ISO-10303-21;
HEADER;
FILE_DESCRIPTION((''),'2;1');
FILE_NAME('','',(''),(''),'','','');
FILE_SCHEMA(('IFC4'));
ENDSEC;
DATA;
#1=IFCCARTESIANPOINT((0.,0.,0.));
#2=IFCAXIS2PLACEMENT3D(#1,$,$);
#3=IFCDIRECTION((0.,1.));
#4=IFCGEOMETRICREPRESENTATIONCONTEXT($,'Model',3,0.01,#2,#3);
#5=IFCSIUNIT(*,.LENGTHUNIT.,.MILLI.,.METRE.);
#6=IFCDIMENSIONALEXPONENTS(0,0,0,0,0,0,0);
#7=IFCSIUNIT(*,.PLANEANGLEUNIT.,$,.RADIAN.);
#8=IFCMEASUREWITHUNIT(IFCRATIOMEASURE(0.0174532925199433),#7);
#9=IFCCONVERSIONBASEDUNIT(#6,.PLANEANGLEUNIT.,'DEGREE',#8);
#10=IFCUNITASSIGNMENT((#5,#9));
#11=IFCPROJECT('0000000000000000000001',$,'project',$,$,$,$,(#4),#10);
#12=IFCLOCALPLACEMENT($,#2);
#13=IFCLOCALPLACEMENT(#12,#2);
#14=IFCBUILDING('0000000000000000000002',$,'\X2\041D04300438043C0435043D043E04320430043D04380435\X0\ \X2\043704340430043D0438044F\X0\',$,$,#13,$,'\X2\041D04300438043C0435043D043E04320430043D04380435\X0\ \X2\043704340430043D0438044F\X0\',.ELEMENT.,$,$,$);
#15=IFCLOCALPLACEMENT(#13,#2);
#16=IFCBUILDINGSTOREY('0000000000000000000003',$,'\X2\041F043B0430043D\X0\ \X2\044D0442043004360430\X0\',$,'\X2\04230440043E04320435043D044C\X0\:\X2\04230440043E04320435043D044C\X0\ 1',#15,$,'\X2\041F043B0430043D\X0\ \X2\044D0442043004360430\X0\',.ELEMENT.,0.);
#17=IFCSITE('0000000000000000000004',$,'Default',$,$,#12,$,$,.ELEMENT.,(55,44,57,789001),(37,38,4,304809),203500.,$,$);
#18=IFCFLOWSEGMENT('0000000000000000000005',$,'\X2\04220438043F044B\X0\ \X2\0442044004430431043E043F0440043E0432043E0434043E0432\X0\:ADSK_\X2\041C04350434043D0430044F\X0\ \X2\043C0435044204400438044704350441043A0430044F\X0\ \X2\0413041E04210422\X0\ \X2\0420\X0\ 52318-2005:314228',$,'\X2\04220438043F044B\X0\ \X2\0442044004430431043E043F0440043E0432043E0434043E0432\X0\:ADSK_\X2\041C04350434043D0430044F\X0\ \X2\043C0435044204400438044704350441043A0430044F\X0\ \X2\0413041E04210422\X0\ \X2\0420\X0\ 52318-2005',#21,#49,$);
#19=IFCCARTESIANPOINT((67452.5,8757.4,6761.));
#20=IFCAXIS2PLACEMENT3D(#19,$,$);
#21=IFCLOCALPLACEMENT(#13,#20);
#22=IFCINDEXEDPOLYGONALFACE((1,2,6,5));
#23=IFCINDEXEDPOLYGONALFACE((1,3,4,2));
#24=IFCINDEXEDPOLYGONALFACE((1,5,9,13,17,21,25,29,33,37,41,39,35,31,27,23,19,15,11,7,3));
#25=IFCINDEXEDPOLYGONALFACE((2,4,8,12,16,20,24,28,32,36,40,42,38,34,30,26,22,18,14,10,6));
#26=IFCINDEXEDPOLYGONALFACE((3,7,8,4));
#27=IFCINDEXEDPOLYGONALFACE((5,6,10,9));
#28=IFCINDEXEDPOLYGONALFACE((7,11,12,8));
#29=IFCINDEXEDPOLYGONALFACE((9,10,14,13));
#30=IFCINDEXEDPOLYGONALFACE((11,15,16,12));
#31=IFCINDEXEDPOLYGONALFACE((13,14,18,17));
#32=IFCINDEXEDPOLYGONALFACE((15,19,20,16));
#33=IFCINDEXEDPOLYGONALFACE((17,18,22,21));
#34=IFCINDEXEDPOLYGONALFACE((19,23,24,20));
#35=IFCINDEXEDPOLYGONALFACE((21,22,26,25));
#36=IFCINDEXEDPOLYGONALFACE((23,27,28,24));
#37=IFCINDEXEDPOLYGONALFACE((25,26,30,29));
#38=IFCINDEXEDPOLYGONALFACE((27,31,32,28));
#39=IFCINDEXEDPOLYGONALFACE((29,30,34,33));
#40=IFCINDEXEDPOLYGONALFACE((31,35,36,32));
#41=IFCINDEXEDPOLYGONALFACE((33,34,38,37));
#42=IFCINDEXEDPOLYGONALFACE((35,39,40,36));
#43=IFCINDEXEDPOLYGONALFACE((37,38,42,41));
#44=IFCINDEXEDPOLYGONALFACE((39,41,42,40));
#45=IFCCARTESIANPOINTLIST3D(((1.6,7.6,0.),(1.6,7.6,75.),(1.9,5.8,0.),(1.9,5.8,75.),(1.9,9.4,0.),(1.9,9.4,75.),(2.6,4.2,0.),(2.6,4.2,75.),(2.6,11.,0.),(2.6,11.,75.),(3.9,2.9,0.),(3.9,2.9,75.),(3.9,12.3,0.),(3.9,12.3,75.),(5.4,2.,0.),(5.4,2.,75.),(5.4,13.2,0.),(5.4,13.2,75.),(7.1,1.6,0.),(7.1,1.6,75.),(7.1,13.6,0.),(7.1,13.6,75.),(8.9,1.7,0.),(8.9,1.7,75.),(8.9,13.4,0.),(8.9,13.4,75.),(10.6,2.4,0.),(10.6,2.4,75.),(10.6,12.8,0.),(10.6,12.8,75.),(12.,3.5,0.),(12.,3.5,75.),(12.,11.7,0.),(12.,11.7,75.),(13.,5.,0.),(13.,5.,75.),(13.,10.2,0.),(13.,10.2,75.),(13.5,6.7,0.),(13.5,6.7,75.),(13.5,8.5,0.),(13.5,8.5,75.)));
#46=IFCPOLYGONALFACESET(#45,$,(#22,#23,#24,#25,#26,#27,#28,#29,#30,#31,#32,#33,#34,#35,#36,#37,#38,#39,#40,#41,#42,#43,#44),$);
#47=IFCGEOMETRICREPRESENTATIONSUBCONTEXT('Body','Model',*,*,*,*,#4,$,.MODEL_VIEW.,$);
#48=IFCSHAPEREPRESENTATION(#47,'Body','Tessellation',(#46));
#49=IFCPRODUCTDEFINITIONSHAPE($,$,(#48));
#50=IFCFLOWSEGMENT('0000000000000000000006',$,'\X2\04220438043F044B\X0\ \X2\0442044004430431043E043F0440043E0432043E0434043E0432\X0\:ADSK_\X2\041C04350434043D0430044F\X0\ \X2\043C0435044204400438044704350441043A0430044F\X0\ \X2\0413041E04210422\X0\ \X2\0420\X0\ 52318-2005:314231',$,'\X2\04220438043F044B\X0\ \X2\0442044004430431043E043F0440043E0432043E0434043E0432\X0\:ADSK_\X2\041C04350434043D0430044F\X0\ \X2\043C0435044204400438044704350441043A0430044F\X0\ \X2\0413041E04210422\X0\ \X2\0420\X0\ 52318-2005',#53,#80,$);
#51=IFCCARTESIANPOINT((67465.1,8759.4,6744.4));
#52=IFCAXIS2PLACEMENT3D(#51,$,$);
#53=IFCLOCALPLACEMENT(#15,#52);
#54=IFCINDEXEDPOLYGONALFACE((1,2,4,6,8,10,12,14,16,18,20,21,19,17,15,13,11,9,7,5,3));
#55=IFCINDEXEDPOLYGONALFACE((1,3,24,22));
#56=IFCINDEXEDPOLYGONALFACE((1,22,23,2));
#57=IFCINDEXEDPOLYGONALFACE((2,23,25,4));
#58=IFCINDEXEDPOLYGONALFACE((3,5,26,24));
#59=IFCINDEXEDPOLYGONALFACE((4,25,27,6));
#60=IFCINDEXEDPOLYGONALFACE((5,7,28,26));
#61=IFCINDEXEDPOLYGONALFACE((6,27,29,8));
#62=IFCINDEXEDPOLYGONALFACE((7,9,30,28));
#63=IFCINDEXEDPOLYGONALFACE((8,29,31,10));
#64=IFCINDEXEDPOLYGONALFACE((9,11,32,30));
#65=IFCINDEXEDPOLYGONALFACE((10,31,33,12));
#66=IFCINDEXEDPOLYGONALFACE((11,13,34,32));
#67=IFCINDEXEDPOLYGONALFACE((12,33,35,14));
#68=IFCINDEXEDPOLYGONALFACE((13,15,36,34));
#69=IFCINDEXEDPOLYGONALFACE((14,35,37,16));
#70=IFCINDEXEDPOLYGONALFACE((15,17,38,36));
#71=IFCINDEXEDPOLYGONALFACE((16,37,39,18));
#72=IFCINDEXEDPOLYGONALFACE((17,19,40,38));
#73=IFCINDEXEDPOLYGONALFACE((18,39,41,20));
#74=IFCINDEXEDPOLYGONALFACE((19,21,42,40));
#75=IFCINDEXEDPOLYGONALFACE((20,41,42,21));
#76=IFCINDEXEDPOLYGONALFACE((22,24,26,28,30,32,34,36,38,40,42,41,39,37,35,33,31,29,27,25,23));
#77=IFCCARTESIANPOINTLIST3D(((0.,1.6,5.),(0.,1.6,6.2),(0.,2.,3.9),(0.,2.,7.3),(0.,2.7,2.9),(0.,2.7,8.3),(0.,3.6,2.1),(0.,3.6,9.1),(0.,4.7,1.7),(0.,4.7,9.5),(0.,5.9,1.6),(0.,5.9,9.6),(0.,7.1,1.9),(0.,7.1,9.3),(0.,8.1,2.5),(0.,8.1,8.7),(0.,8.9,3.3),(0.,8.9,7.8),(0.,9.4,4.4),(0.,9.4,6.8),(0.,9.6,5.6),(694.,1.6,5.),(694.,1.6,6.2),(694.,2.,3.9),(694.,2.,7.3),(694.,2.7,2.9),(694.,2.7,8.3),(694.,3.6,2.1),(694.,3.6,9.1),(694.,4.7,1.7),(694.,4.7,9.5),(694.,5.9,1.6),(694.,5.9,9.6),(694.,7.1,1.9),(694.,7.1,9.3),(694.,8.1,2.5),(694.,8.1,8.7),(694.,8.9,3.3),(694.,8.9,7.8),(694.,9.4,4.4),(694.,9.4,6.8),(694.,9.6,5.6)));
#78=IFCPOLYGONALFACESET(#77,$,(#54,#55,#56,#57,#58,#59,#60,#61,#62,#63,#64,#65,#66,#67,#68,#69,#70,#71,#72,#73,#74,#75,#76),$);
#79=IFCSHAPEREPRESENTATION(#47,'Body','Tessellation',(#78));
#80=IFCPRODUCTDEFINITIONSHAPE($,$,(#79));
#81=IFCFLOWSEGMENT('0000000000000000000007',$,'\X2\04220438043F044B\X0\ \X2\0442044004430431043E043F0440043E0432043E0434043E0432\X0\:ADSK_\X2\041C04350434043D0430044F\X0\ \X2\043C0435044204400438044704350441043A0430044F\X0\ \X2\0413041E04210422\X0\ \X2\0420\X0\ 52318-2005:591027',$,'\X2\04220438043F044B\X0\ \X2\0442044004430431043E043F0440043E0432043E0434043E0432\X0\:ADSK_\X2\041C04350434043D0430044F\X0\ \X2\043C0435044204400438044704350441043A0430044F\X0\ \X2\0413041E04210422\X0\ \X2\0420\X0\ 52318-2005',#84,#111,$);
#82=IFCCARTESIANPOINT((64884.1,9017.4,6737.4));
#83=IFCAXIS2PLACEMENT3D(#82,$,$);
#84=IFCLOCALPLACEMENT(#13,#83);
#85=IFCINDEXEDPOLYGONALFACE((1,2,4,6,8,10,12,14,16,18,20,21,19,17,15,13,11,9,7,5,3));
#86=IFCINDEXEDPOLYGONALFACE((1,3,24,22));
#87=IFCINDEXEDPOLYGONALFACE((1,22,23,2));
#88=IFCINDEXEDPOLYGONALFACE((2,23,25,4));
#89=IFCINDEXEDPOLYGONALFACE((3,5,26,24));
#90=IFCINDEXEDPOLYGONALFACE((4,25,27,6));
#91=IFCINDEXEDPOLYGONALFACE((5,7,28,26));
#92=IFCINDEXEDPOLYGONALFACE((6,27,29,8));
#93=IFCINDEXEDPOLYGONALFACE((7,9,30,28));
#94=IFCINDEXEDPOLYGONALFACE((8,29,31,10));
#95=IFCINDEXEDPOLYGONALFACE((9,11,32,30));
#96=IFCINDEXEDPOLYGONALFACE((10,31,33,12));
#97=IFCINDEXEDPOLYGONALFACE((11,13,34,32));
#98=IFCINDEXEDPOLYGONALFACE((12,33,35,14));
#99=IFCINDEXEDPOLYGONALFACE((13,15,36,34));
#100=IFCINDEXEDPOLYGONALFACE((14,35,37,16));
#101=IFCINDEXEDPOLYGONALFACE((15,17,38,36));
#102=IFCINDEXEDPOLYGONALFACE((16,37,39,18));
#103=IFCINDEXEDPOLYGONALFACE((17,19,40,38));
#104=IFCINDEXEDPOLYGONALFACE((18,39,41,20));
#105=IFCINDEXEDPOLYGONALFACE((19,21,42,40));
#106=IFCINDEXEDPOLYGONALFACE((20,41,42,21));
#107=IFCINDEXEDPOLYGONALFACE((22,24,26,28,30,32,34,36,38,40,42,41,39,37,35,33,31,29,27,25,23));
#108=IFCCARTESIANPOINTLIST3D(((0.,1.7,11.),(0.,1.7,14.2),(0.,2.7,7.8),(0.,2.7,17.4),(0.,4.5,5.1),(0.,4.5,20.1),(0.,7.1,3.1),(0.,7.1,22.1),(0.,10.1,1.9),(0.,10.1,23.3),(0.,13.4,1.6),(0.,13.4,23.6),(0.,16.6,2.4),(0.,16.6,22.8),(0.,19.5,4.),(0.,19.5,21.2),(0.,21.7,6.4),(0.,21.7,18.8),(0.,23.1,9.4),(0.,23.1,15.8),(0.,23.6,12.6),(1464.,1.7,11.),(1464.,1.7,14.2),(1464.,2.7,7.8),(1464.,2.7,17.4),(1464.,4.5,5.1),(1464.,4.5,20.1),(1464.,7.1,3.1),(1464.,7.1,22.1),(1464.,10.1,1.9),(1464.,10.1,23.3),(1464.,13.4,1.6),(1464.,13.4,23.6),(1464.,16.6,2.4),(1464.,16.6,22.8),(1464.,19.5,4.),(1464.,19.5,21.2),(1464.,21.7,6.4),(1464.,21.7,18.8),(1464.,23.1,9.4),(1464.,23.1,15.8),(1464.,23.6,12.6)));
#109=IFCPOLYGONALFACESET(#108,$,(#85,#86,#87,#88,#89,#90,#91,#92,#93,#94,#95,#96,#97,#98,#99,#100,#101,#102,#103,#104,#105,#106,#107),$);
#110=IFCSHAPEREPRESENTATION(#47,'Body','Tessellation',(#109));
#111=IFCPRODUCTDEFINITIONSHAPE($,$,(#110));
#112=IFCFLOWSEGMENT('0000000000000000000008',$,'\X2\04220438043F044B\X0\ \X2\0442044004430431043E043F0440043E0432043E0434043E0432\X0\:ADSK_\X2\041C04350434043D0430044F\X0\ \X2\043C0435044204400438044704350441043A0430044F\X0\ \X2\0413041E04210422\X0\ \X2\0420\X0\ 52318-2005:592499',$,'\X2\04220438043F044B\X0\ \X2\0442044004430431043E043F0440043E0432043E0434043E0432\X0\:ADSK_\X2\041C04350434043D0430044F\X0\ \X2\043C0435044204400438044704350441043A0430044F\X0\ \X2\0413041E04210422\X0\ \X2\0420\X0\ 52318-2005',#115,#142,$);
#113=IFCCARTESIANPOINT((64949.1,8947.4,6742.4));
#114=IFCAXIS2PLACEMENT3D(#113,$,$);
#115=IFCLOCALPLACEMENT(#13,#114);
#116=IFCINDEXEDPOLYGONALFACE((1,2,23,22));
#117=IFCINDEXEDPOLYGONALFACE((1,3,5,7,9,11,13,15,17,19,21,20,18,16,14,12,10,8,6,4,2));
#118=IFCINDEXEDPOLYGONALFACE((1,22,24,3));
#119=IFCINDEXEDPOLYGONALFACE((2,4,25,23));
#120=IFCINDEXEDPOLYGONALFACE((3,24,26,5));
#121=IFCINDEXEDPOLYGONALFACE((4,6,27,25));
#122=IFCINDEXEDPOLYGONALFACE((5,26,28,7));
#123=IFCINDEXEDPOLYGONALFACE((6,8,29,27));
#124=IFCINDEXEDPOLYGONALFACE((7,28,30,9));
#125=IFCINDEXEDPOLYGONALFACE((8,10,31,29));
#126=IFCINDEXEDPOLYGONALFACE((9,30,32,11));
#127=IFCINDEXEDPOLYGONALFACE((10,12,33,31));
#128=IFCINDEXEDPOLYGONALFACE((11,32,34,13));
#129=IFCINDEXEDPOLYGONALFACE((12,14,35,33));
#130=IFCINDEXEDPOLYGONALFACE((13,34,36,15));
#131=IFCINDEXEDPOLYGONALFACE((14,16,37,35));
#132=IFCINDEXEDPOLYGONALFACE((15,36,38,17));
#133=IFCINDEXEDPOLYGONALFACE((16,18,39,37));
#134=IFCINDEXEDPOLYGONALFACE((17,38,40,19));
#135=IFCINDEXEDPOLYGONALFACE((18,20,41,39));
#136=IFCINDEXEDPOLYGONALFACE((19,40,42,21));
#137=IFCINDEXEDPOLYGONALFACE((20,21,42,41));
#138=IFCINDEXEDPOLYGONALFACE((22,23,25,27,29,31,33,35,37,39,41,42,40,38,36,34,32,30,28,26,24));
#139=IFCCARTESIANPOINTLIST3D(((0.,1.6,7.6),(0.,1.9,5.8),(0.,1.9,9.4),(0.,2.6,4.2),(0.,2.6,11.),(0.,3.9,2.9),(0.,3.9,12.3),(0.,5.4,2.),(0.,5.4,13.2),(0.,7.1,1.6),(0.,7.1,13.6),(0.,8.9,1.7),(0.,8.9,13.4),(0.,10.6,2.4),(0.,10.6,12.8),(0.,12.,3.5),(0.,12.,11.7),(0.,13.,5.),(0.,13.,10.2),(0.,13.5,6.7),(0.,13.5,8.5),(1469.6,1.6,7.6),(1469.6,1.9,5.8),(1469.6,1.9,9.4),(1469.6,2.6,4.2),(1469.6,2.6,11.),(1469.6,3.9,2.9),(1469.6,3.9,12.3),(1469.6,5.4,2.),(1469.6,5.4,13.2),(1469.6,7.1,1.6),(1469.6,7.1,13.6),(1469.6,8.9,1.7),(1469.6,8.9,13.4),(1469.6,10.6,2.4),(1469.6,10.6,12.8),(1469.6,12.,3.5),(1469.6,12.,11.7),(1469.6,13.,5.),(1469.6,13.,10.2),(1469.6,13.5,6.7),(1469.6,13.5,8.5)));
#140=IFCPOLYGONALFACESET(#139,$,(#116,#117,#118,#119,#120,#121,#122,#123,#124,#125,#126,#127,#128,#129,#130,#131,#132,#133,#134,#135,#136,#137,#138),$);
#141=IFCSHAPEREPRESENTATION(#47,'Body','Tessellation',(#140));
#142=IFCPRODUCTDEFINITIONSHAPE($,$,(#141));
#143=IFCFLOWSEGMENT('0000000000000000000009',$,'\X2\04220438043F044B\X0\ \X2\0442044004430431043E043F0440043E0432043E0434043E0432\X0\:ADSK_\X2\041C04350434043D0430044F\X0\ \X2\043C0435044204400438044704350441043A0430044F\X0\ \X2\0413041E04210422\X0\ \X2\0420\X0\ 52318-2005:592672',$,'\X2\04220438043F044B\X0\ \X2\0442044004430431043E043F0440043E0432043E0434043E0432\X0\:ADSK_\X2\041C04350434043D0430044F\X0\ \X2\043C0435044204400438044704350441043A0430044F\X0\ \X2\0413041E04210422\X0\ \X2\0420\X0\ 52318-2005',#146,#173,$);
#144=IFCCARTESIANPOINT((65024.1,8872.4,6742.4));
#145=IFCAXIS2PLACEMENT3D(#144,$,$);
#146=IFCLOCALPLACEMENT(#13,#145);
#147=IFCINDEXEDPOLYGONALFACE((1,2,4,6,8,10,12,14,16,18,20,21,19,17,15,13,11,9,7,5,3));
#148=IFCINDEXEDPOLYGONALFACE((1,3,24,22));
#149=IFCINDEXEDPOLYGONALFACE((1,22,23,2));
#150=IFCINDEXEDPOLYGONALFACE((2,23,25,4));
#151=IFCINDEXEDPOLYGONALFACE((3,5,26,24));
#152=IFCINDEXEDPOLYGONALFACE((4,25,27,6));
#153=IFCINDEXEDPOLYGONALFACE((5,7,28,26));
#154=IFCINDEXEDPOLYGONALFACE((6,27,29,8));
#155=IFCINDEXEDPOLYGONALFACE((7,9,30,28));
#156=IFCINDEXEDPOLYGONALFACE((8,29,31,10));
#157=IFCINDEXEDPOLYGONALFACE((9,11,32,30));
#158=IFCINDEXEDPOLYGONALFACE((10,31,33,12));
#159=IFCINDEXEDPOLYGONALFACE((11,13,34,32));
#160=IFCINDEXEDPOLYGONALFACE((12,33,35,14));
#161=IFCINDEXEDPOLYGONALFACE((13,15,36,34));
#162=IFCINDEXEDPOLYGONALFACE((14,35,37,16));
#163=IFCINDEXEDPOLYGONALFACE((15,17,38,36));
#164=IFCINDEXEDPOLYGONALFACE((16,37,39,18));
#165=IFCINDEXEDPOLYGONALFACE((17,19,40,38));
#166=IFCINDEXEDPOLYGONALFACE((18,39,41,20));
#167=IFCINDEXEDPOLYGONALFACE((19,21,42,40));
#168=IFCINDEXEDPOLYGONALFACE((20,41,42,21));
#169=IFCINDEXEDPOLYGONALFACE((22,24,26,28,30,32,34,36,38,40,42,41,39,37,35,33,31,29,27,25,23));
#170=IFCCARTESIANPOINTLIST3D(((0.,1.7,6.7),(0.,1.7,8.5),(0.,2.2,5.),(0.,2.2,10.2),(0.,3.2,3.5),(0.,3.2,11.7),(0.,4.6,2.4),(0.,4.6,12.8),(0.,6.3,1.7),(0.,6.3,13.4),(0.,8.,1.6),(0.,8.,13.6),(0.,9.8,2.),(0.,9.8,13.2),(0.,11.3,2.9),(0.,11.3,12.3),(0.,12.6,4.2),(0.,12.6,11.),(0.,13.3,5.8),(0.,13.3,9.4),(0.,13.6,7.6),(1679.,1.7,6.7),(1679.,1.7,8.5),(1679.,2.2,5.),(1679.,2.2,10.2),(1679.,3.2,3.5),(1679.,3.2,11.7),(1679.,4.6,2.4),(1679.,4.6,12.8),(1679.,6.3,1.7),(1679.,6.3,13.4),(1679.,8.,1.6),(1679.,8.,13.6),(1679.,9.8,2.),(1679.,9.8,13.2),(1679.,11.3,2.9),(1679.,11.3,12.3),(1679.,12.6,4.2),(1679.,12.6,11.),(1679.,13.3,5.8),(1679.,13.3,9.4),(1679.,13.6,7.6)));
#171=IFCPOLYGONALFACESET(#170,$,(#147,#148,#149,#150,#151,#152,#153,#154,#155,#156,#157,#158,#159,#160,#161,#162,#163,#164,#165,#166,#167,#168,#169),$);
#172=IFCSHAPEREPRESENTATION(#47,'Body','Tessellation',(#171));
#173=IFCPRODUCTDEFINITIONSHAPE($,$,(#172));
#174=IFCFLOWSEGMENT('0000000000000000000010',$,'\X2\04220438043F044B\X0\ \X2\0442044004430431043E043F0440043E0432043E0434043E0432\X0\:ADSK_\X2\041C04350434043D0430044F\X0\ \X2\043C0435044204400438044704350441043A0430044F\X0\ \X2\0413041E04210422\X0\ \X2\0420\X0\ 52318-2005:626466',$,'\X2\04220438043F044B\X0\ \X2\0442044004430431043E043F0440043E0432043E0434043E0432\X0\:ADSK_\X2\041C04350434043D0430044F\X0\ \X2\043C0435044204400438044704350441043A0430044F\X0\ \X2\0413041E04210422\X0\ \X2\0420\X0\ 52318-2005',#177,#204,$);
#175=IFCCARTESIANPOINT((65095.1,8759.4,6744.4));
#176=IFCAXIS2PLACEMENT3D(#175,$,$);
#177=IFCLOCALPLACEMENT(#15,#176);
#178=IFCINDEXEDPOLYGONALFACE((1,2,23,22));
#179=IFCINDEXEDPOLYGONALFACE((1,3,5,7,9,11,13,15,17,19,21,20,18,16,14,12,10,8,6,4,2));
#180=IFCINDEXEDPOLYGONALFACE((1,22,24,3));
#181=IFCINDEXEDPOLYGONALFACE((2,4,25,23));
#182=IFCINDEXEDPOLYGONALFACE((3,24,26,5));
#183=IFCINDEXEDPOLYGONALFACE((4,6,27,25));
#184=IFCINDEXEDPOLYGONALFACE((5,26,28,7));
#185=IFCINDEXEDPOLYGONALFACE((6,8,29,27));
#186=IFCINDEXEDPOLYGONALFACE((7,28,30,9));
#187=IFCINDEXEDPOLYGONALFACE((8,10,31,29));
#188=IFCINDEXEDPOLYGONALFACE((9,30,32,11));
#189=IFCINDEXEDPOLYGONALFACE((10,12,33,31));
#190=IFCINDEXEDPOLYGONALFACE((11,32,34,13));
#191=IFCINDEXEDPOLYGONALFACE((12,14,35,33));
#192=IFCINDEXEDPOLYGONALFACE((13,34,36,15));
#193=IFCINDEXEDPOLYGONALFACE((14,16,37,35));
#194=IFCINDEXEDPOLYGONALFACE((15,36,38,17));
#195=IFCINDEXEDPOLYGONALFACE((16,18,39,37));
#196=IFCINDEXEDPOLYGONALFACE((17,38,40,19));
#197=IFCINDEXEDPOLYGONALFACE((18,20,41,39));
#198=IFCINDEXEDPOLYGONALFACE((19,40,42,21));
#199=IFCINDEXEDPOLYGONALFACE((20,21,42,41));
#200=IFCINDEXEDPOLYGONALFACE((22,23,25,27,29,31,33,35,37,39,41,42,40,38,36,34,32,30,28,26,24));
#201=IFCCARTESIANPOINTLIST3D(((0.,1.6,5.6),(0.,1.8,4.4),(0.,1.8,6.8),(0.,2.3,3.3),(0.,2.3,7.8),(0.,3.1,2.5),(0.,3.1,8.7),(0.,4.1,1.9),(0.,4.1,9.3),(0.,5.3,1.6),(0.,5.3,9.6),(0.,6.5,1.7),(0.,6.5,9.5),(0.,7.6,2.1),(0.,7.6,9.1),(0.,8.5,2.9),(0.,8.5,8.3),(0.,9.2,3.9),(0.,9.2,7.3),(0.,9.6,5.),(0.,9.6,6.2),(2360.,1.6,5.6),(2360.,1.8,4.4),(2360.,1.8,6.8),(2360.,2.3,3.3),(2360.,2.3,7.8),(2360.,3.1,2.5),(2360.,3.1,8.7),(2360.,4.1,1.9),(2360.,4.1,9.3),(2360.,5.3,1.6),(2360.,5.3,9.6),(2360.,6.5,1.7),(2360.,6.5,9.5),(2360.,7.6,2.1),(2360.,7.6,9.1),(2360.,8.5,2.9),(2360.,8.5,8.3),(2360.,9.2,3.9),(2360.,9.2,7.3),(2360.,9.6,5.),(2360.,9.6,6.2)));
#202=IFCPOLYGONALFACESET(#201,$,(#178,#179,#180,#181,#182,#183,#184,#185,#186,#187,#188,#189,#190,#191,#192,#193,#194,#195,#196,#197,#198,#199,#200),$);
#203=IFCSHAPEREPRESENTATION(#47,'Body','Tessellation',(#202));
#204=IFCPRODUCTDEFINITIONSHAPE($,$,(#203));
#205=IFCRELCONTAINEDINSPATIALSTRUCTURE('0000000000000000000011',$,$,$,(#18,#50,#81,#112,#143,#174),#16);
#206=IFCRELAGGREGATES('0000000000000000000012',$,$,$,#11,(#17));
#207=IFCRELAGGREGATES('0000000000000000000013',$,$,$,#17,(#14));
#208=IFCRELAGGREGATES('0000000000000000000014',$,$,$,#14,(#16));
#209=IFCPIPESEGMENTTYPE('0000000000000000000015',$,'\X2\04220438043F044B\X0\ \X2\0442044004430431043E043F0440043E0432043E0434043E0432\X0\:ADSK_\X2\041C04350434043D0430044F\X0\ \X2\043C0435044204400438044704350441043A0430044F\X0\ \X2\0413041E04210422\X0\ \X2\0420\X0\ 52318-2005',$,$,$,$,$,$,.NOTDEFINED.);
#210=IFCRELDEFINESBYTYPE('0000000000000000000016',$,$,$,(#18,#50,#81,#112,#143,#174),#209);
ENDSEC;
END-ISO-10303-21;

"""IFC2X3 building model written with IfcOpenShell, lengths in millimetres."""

from ifc_helpers import new_model, entity, si_unit, converted_unit, direction, frame, frame_2d, origin, place, context, subcontext, project, spatial, circle, extrude, type_object, element, save


model = new_model("IFC2X3")

# Units and contexts
model_context = context("Model", 3, precision=0.01, world=origin(), true_north=direction((0.0, 1.0)))
body_context = subcontext(model_context, "Body", "Model", "MODEL_VIEW")
ifc_project = project(units=[si_unit("LENGTHUNIT", "METRE", prefix="MILLI"), converted_unit("PLANEANGLEUNIT", "DEGREE", entity("IfcRatioMeasure", 0.0174532925199433), si_unit("PLANEANGLEUNIT", "RADIAN"), dimensions=[0, 0, 0, 0, 0, 0, 0])], contexts=[model_context])

# Site, building, storey
site_placement = place(None, frame((0.0, 0.0, 0.0)))
site = spatial("IfcSite", under=ifc_project, at=site_placement, Name="Default", CompositionType="ELEMENT", RefLatitude=(55, 44, 57, 789001), RefLongitude=(37, 38, 4, 304809), RefElevation=203500.0)
building_placement = place(site_placement, origin())
building = spatial("IfcBuilding", under=site, at=building_placement, Name="Наименование здания", LongName="Наименование здания", CompositionType="ELEMENT")
storey_placement = place(building_placement, origin())
storey = spatial("IfcBuildingStorey", under=building, at=storey_placement, Name="План этажа", ObjectType="Уровень:Уровень 1", LongName="План этажа", CompositionType="ELEMENT", Elevation=0.0)

# Flow segments
pipe_segment_type = type_object("IfcPipeSegmentType", Name="Типы трубопроводов:ADSK_Медная метрическая ГОСТ Р 52318-2005", PredefinedType="NOTDEFINED")
flow_segment_1_placement = place(building_placement, frame((67452.5, 8757.4, 6761.0)))
element("IfcFlowSegment", 1, at=flow_segment_1_placement, inside=storey, type_object=pipe_segment_type, Name="Типы трубопроводов:ADSK_Медная метрическая ГОСТ Р 52318-2005:314228", ObjectType="Типы трубопроводов:ADSK_Медная метрическая ГОСТ Р 52318-2005", context=body_context, shape_type="SweptSolid", body=[
    extrude(circle(Radius=6.0, at=frame_2d((0.0, 0.0), x_axis=(1.0, 0.0))), frame((7.6, 7.6, 0.0), z_axis=(0.0, 0.0, 1.0), x_axis=(-1.0, 0.0, 0.0)), (0.0, 0.0, 1.0), 75.0),
])
flow_segment_2_placement = place(storey_placement, frame((67465.1, 8759.4, 6744.4)))
element("IfcFlowSegment", 2, at=flow_segment_2_placement, inside=storey, type_object=pipe_segment_type, Name="Типы трубопроводов:ADSK_Медная метрическая ГОСТ Р 52318-2005:314231", ObjectType="Типы трубопроводов:ADSK_Медная метрическая ГОСТ Р 52318-2005", context=body_context, shape_type="SweptSolid", body=[
    extrude(circle(Radius=4.0, at=frame_2d((0.0, 0.0), x_axis=(1.0, 0.0))), frame((0.0, 5.6, 5.6), z_axis=(1.0, 0.0, 0.0), x_axis=(0.0, 1.0, 0.0)), (0.0, 0.0, 1.0), 694.0),
])
flow_segment_3_placement = place(building_placement, frame((64884.1, 9017.4, 6737.4)))
element("IfcFlowSegment", 3, at=flow_segment_3_placement, inside=storey, type_object=pipe_segment_type, Name="Типы трубопроводов:ADSK_Медная метрическая ГОСТ Р 52318-2005:591027", ObjectType="Типы трубопроводов:ADSK_Медная метрическая ГОСТ Р 52318-2005", context=body_context, shape_type="SweptSolid", body=[
    extrude(circle(Radius=11.0, at=frame_2d((0.0, 0.0), x_axis=(1.0, 0.0))), frame((0.0, 12.6, 12.6), z_axis=(1.0, 0.0, 0.0), x_axis=(0.0, 1.0, 0.0)), (0.0, 0.0, 1.0), 1464.0),
])
flow_segment_4_placement = place(building_placement, frame((64949.1, 8947.4, 6742.4)))
element("IfcFlowSegment", 4, at=flow_segment_4_placement, inside=storey, type_object=pipe_segment_type, Name="Типы трубопроводов:ADSK_Медная метрическая ГОСТ Р 52318-2005:592499", ObjectType="Типы трубопроводов:ADSK_Медная метрическая ГОСТ Р 52318-2005", context=body_context, shape_type="SweptSolid", body=[
    extrude(circle(Radius=6.0, at=frame_2d((0.0, 0.0), x_axis=(1.0, 0.0))), frame((0.0, 7.6, 7.6), z_axis=(1.0, 0.0, 0.0), x_axis=(0.0, -1.0, 0.0)), (0.0, 0.0, 1.0), 1469.6),
])
flow_segment_5_placement = place(building_placement, frame((65024.1, 8872.4, 6742.4)))
element("IfcFlowSegment", 5, at=flow_segment_5_placement, inside=storey, type_object=pipe_segment_type, Name="Типы трубопроводов:ADSK_Медная метрическая ГОСТ Р 52318-2005:592672", ObjectType="Типы трубопроводов:ADSK_Медная метрическая ГОСТ Р 52318-2005", context=body_context, shape_type="SweptSolid", body=[
    extrude(circle(Radius=6.0, at=frame_2d((0.0, 0.0), x_axis=(1.0, 0.0))), frame((0.0, 7.6, 7.6), z_axis=(1.0, 0.0, 0.0), x_axis=(0.0, 1.0, 0.0)), (0.0, 0.0, 1.0), 1679.0),
])
flow_segment_6_placement = place(storey_placement, frame((65095.1, 8759.4, 6744.4)))
element("IfcFlowSegment", 6, at=flow_segment_6_placement, inside=storey, type_object=pipe_segment_type, Name="Типы трубопроводов:ADSK_Медная метрическая ГОСТ Р 52318-2005:626466", ObjectType="Типы трубопроводов:ADSK_Медная метрическая ГОСТ Р 52318-2005", context=body_context, shape_type="SweptSolid", body=[
    extrude(circle(Radius=4.0, at=frame_2d((0.0, 0.0), x_axis=(1.0, 0.0))), frame((0.0, 5.6, 5.6), z_axis=(1.0, 0.0, 0.0), x_axis=(0.0, -1.0, 0.0)), (0.0, 0.0, 1.0), 2360.0),
])

save(model, "model.ifc")
